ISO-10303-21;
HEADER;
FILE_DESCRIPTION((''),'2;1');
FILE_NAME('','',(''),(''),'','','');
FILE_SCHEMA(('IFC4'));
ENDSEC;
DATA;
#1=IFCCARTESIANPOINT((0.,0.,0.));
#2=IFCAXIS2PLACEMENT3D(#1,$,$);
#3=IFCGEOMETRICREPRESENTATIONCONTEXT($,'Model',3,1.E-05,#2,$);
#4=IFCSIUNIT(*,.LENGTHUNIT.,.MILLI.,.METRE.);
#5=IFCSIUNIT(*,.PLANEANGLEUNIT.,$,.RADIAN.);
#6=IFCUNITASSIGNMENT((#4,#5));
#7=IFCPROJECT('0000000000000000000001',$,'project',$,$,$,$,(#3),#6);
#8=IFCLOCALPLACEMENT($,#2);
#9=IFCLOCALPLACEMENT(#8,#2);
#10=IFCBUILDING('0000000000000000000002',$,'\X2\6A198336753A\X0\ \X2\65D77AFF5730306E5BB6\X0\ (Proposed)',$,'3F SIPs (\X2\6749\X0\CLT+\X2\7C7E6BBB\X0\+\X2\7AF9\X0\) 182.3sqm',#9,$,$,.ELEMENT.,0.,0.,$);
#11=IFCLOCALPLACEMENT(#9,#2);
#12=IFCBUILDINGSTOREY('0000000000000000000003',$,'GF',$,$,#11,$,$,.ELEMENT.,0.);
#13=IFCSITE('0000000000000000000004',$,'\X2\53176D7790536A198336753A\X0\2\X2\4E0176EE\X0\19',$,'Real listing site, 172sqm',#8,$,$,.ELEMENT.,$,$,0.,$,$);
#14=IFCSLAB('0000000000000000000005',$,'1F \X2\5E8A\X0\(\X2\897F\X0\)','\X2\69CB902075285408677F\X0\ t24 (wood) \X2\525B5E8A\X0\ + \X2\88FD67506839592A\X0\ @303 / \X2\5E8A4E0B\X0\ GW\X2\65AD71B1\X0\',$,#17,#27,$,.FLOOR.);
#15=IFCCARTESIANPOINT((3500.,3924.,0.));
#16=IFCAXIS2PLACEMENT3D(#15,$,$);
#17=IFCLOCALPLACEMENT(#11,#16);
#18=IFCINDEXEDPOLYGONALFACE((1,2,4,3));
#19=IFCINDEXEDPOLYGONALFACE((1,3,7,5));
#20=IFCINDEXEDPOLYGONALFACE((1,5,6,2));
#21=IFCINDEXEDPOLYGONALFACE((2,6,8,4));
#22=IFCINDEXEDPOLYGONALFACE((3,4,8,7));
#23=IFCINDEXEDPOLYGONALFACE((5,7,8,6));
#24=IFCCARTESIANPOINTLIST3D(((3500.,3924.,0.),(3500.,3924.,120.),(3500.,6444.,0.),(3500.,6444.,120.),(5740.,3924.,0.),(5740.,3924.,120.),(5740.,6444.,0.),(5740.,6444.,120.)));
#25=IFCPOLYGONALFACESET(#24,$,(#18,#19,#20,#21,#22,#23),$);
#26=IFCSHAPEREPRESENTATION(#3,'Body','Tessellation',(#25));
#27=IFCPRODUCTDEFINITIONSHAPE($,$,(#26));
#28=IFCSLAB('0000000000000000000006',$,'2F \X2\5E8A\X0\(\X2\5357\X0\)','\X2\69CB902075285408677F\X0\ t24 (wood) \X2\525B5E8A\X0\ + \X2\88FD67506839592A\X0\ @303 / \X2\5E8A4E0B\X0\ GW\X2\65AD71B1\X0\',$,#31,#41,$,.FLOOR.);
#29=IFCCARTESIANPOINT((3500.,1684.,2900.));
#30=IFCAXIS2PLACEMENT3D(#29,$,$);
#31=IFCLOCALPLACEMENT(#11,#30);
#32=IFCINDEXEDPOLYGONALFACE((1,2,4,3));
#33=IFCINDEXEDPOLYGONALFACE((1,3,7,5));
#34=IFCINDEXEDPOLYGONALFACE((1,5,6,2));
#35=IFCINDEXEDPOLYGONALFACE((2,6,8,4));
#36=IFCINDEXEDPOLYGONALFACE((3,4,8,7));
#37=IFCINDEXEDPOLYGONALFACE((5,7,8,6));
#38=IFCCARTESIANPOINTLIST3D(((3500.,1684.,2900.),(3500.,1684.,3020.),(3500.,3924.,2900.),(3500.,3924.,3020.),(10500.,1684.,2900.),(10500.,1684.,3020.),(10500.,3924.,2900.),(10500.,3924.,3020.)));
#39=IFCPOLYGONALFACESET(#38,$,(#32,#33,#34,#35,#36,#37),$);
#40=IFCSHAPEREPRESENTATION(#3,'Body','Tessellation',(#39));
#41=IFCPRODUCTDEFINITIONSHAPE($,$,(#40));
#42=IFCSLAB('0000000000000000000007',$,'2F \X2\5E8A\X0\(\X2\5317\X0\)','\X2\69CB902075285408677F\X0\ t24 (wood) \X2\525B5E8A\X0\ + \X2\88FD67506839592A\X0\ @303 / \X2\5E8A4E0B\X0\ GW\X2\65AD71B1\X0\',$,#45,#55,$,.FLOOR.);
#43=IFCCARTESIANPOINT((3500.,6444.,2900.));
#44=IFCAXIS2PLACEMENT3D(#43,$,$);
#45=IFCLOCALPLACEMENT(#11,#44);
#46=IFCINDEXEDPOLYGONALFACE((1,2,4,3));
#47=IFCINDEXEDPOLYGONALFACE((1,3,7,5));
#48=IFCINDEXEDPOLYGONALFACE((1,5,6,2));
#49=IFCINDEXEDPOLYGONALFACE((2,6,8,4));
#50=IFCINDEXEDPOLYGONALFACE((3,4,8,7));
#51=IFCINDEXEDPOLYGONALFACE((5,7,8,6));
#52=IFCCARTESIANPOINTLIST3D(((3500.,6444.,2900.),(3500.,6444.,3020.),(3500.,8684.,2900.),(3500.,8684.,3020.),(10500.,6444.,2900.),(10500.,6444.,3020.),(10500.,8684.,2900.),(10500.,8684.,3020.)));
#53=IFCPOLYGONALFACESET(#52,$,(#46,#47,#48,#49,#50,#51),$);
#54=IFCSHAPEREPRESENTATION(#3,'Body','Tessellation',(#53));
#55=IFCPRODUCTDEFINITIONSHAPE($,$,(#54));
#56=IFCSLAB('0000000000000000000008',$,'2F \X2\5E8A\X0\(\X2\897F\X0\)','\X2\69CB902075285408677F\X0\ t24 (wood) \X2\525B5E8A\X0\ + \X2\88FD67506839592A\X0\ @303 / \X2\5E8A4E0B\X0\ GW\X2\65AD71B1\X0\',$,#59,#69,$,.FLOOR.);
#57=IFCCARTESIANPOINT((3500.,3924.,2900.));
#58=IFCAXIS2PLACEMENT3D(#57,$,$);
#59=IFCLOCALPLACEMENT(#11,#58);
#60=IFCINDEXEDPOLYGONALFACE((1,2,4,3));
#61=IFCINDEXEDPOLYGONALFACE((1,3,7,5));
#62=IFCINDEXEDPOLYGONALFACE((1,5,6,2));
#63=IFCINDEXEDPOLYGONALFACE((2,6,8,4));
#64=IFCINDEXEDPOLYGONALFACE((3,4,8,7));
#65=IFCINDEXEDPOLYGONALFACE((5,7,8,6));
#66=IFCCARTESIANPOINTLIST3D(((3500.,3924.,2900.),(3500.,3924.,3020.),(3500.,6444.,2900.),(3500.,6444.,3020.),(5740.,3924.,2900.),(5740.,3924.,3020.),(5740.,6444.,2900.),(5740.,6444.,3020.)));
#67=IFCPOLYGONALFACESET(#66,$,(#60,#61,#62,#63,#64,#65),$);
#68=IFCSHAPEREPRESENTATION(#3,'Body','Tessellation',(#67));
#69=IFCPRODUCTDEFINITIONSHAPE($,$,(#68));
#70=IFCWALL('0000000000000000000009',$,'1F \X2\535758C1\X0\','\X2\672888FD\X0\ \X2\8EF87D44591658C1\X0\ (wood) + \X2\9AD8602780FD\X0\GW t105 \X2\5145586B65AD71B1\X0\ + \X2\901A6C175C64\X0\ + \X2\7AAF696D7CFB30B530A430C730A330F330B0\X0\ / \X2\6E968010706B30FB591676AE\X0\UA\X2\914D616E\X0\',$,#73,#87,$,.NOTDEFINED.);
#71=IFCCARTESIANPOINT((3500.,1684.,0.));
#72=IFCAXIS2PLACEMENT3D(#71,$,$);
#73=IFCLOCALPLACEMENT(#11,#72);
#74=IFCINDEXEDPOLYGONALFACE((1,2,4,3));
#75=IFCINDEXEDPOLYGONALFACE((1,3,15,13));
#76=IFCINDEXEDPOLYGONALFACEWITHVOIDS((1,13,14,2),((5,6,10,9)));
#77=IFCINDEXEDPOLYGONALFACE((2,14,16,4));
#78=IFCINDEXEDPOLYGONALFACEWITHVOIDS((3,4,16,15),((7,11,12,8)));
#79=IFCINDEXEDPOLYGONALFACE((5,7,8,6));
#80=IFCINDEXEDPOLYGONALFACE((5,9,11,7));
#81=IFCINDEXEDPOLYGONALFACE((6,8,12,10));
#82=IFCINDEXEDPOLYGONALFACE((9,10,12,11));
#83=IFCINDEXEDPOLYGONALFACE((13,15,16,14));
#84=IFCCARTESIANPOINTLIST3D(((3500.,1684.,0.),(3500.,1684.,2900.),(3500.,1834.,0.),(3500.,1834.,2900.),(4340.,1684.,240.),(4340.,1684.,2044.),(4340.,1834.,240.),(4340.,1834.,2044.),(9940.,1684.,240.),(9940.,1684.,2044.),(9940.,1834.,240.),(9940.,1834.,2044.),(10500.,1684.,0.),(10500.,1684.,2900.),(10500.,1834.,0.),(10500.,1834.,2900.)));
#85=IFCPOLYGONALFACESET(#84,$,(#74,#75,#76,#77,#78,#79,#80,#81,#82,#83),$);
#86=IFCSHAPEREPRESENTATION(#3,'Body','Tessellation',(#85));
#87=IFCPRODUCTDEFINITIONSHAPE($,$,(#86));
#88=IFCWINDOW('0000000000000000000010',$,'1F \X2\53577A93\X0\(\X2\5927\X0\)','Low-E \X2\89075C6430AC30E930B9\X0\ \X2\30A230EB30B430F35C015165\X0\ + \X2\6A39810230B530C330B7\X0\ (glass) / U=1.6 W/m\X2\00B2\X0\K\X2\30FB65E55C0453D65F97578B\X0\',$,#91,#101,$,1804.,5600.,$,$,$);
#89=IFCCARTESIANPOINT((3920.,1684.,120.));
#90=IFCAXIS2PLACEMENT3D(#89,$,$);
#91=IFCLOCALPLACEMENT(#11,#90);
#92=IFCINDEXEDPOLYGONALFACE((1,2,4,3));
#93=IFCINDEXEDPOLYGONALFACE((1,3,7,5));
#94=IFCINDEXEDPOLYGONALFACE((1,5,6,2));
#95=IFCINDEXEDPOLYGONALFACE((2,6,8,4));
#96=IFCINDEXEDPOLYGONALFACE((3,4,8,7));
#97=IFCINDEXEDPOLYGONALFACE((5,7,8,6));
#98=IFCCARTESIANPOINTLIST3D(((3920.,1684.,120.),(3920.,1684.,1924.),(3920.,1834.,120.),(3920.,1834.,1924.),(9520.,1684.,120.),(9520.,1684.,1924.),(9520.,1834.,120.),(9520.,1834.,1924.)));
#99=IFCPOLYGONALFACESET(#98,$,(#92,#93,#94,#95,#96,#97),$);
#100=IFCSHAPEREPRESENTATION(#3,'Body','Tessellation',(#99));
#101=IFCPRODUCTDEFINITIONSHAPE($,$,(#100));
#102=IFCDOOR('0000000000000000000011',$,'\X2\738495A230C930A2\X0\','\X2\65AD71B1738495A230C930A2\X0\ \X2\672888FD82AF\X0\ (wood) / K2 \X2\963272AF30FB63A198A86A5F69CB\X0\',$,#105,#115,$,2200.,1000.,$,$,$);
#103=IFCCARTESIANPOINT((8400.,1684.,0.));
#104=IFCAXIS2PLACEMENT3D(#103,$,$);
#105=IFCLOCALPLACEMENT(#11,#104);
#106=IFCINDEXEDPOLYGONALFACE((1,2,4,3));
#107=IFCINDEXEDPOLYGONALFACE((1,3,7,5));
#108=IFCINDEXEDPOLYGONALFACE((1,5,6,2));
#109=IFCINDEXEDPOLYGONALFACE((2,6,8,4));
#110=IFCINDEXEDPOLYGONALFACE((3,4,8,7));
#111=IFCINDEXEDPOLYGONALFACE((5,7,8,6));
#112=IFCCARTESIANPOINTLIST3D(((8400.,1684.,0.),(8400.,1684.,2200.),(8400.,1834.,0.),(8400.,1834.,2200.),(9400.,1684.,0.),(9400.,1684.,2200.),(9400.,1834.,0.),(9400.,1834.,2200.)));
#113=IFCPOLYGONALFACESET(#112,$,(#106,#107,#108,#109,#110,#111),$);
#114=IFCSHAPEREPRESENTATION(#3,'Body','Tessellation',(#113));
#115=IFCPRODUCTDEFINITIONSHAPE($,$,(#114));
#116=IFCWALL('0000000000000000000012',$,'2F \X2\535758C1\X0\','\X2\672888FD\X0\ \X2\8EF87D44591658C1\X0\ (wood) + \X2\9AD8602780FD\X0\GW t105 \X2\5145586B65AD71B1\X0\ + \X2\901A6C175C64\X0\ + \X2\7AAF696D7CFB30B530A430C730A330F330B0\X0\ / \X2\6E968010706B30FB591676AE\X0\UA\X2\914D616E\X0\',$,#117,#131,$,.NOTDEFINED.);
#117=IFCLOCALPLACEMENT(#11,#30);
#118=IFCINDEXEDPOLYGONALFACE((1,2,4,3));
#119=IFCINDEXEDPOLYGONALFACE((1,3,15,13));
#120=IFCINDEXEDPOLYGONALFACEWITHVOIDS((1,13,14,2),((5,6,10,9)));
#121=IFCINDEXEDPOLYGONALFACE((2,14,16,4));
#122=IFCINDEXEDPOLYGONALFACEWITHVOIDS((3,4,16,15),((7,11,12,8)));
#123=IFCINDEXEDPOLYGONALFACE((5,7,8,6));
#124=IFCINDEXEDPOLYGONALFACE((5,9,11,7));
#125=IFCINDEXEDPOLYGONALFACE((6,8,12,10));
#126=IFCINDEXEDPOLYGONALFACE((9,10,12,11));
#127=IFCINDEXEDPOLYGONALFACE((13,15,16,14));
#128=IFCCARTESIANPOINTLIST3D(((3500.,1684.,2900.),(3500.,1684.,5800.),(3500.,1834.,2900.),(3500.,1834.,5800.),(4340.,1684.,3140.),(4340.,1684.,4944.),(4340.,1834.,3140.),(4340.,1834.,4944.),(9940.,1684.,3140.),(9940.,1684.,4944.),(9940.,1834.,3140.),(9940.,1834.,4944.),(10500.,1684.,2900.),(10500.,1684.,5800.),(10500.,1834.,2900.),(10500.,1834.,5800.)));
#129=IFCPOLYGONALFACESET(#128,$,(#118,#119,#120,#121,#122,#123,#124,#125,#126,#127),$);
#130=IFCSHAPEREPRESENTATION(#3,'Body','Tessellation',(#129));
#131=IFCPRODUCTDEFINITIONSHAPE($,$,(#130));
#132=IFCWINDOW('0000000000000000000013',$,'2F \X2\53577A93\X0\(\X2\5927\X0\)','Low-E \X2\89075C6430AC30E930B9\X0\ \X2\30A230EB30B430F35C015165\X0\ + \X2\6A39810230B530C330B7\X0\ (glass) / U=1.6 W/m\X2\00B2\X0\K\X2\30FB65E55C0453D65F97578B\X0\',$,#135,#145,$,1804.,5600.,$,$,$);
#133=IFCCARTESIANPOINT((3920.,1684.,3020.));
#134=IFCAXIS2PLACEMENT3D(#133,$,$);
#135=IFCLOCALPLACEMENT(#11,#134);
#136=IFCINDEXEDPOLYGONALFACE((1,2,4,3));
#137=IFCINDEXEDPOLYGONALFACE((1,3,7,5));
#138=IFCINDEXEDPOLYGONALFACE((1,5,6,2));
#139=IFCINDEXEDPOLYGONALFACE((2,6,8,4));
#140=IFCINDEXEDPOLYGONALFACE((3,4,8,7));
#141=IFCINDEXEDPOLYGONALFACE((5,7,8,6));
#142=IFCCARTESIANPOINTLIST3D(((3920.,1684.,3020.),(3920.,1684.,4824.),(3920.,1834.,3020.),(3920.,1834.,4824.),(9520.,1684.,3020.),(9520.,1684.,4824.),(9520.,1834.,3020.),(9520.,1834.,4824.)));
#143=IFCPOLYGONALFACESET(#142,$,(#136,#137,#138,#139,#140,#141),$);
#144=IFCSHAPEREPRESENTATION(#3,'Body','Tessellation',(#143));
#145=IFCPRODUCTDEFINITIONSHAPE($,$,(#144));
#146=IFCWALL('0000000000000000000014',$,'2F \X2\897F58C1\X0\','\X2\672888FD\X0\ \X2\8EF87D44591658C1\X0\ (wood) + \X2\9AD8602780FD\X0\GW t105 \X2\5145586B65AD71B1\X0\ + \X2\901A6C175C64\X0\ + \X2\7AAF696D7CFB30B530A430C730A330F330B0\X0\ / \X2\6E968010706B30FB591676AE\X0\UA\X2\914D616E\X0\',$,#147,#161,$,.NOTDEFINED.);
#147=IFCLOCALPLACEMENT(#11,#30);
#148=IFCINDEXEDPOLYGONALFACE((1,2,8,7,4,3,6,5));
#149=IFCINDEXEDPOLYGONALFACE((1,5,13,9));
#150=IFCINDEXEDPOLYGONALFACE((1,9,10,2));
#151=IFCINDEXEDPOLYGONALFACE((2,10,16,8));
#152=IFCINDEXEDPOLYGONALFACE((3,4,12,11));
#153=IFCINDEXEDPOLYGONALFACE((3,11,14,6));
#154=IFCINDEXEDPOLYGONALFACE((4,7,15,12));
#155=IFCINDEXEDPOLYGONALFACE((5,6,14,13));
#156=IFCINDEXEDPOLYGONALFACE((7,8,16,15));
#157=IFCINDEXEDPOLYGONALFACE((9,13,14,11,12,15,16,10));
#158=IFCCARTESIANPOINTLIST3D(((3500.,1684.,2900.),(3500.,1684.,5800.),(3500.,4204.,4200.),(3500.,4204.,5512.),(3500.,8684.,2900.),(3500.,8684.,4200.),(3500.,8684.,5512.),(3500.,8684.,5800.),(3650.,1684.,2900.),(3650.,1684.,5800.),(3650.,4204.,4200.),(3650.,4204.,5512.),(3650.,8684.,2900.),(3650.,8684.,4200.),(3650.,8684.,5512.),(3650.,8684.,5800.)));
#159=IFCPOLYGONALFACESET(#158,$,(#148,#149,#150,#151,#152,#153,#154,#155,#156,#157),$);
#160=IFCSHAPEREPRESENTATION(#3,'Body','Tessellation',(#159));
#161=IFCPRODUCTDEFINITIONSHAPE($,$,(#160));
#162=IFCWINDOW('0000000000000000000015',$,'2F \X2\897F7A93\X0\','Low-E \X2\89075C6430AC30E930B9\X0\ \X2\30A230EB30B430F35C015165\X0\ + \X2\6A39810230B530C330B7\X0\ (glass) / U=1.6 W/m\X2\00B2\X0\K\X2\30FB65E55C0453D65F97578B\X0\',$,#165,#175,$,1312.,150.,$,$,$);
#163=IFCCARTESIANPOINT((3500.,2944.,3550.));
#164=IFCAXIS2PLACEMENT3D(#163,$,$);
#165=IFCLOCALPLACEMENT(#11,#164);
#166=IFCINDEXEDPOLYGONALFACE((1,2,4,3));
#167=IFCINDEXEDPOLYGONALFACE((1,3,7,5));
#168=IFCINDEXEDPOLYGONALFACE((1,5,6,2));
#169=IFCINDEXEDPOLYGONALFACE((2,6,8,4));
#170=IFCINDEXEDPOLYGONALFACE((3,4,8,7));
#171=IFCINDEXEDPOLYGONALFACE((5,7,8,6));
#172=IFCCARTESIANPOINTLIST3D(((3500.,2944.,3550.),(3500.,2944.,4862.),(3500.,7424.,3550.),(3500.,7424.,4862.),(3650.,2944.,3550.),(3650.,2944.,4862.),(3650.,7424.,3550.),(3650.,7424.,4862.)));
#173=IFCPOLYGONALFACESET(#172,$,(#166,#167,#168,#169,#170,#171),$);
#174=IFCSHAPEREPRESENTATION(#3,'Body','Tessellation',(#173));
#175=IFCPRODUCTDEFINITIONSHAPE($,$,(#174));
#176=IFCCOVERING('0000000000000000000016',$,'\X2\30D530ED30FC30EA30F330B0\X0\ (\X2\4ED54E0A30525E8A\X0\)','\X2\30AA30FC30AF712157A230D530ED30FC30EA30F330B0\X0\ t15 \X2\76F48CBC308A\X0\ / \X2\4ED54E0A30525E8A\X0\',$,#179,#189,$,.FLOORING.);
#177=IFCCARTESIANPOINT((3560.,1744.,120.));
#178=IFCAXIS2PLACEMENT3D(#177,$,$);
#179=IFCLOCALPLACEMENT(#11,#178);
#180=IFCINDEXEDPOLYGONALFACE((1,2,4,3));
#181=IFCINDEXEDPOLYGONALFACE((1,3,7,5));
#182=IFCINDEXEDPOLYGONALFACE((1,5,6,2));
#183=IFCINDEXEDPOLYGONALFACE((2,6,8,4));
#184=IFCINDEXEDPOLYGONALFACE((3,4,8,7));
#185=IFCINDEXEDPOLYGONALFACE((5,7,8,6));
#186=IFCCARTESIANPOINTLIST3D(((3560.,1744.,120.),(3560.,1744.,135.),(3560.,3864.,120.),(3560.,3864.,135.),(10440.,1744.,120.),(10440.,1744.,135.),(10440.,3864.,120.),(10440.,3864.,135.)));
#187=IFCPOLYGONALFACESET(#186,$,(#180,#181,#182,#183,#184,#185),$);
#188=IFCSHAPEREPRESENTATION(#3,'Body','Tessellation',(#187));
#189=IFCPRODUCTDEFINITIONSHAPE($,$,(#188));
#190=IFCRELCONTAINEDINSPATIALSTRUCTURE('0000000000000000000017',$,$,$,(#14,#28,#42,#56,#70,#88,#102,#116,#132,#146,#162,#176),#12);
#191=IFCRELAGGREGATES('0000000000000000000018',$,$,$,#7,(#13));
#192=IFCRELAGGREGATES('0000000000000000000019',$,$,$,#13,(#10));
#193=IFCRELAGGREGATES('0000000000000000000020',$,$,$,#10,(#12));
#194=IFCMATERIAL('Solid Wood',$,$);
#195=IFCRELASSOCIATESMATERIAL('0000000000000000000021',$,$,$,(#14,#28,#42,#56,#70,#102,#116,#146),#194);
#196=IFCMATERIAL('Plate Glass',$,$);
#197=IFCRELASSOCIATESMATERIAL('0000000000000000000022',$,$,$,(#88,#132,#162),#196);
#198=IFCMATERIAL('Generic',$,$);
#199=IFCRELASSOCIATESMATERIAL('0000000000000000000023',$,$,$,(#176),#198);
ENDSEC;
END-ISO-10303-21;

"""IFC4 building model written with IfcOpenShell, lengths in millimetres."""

from ifc_helpers import new_model, si_unit, frame, frame_2d, origin, place, context, project, spatial, rectangle, extrude, material, element, fill, save


model = new_model("IFC4")

# Units and contexts
model_context = context("Model", 3, precision=1e-05, world=origin())
ifc_project = project(units=[si_unit("LENGTHUNIT", "METRE", prefix="MILLI"), si_unit("PLANEANGLEUNIT", "RADIAN")], contexts=[model_context])

# Site, building, storey
site_placement = place(None, origin())
site = spatial("IfcSite", under=ifc_project, at=site_placement, Name="北海道標茶町2丁目19", ObjectType="Real listing site, 172sqm", CompositionType="ELEMENT", RefElevation=0.0)
building_placement = place(site_placement, origin())
building = spatial("IfcBuilding", under=site, at=building_placement, Name="標茶町 旗竿地の家 (Proposed)", ObjectType="3F SIPs (杉CLT+籾殻+竹) 182.3sqm", CompositionType="ELEMENT", ElevationOfRefHeight=0.0, ElevationOfTerrain=0.0)
storey_placement = place(building_placement, origin())
storey = spatial("IfcBuildingStorey", under=building, at=storey_placement, Name="GF", CompositionType="ELEMENT", Elevation=0.0)

# Slabs
ifc_material_1 = material(Name="Solid Wood")
slab_1_placement = place(storey_placement, frame((3500.0, 3924.0, 0.0)))
element("IfcSlab", 1, at=slab_1_placement, inside=storey, material=ifc_material_1, Name="1F 床(西)", Description="構造用合板 t24 (wood) 剛床 + 製材根太 @303 / 床下 GW断熱", PredefinedType="FLOOR", context=model_context, shape_type="SweptSolid", body=[
    extrude(rectangle(XDim=2240.0, YDim=2520.0, at=frame_2d((1120.0, 1260.0))), frame((3500.0, 3924.0, 0.0)), (0.0, 0.0, 1.0), 120.0),
])
slab_2_placement = place(storey_placement, frame((3500.0, 1684.0, 2900.0)))
element("IfcSlab", 2, at=slab_2_placement, inside=storey, material=ifc_material_1, Name="2F 床(南)", Description="構造用合板 t24 (wood) 剛床 + 製材根太 @303 / 床下 GW断熱", PredefinedType="FLOOR", context=model_context, shape_type="SweptSolid", body=[
    extrude(rectangle(XDim=7000.0, YDim=2240.0, at=frame_2d((3500.0, 1120.0))), frame((3500.0, 1684.0, 2900.0)), (0.0, 0.0, 1.0), 120.0),
])
slab_3_placement = place(storey_placement, frame((3500.0, 6444.0, 2900.0)))
element("IfcSlab", 3, at=slab_3_placement, inside=storey, material=ifc_material_1, Name="2F 床(北)", Description="構造用合板 t24 (wood) 剛床 + 製材根太 @303 / 床下 GW断熱", PredefinedType="FLOOR", context=model_context, shape_type="SweptSolid", body=[
    extrude(rectangle(XDim=7000.0, YDim=2240.0, at=frame_2d((3500.0, 1120.0))), frame((3500.0, 6444.0, 2900.0)), (0.0, 0.0, 1.0), 120.0),
])
slab_4_placement = place(storey_placement, frame((3500.0, 3924.0, 2900.0)))
element("IfcSlab", 4, at=slab_4_placement, inside=storey, material=ifc_material_1, Name="2F 床(西)", Description="構造用合板 t24 (wood) 剛床 + 製材根太 @303 / 床下 GW断熱", PredefinedType="FLOOR", context=model_context, shape_type="SweptSolid", body=[
    extrude(rectangle(XDim=2240.0, YDim=2520.0, at=frame_2d((1120.0, 1260.0))), frame((3500.0, 3924.0, 2900.0)), (0.0, 0.0, 1.0), 120.0),
])

# Wall, openings, window, door
wall_1_placement = place(storey_placement, frame((3500.0, 1684.0, 0.0)))
wall_1 = element("IfcWall", 5, at=wall_1_placement, inside=storey, material=ifc_material_1, Name="1F 南壁", Description="木製 軸組外壁 (wood) + 高性能GW t105 充填断熱 + 通気層 + 窯業系サイディング / 準耐火・外皮UA配慮", PredefinedType="NOTDEFINED", context=model_context, shape_type="SweptSolid", body=[
    extrude(rectangle(XDim=7000.0, YDim=150.0, at=frame_2d((3500.0, 75.0))), frame((3500.0, 1684.0, 0.0)), (0.0, 0.0, 1.0), 2900.0),
])
opening_1_placement = place(storey_placement, frame((3920.0, 1684.0, 120.0)))
opening_1 = element("IfcOpeningElement", 6, at=opening_1_placement, cuts=wall_1, PredefinedType="NOTDEFINED", context=model_context, shape_type="SweptSolid", body=[
    extrude(rectangle(XDim=5600.0, YDim=150.0, at=frame_2d((2800.0, 75.0))), frame((3920.0, 1684.0, 120.0)), (0.0, 0.0, 1.0), 1804.0),
])
opening_2_placement = place(storey_placement, frame((8400.0, 1684.0, 0.0)))
opening_2 = element("IfcOpeningElement", 7, at=opening_2_placement, cuts=wall_1, PredefinedType="NOTDEFINED", context=model_context, shape_type="SweptSolid", body=[
    extrude(rectangle(XDim=1000.0, YDim=150.0, at=frame_2d((500.0, 75.0))), frame((8400.0, 1684.0, 0.0)), (0.0, 0.0, 1.0), 2200.0),
])
ifc_material_2 = material(Name="Plate Glass")
window_1_placement = place(storey_placement, frame((3920.0, 1684.0, 120.0)))
window_1 = element("IfcWindow", 8, at=window_1_placement, inside=storey, material=ifc_material_2, Name="1F 南窓(大)", Description="Low-E 複層ガラス アルゴン封入 + 樹脂サッシ (glass) / U=1.6 W/m²K・日射取得型", OverallHeight=1804.0, OverallWidth=5600.0, context=model_context, shape_type="SweptSolid", body=[
    extrude(rectangle(XDim=5600.0, YDim=150.0, at=frame_2d((2800.0, 75.0))), frame((3920.0, 1684.0, 120.0)), (0.0, 0.0, 1.0), 1804.0),
])
fill(opening_1, window_1)
door_placement = place(storey_placement, frame((8400.0, 1684.0, 0.0)))
door = element("IfcDoor", 9, at=door_placement, inside=storey, material=ifc_material_1, Name="玄関ドア", Description="断熱玄関ドア 木製芯 (wood) / K2 防犯・採風機構", OverallHeight=2200.0, OverallWidth=1000.0, context=model_context, shape_type="SweptSolid", body=[
    extrude(rectangle(XDim=1000.0, YDim=150.0, at=frame_2d((500.0, 75.0))), frame((8400.0, 1684.0, 0.0)), (0.0, 0.0, 1.0), 2200.0),
])
fill(opening_2, door)

# Wall, opening, window
wall_2_placement = place(storey_placement, frame((3500.0, 1684.0, 2900.0)))
wall_2 = element("IfcWall", 10, at=wall_2_placement, inside=storey, material=ifc_material_1, Name="2F 南壁", Description="木製 軸組外壁 (wood) + 高性能GW t105 充填断熱 + 通気層 + 窯業系サイディング / 準耐火・外皮UA配慮", PredefinedType="NOTDEFINED", context=model_context, shape_type="SweptSolid", body=[
    extrude(rectangle(XDim=7000.0, YDim=150.0, at=frame_2d((3500.0, 75.0))), frame((3500.0, 1684.0, 2900.0)), (0.0, 0.0, 1.0), 2900.0),
])
opening_3_placement = place(storey_placement, frame((3920.0, 1684.0, 3020.0)))
opening_3 = element("IfcOpeningElement", 11, at=opening_3_placement, cuts=wall_2, PredefinedType="NOTDEFINED", context=model_context, shape_type="SweptSolid", body=[
    extrude(rectangle(XDim=5600.0, YDim=150.0, at=frame_2d((2800.0, 75.0))), frame((3920.0, 1684.0, 3020.0)), (0.0, 0.0, 1.0), 1804.0),
])
window_2_placement = place(storey_placement, frame((3920.0, 1684.0, 3020.0)))
window_2 = element("IfcWindow", 12, at=window_2_placement, inside=storey, material=ifc_material_2, Name="2F 南窓(大)", Description="Low-E 複層ガラス アルゴン封入 + 樹脂サッシ (glass) / U=1.6 W/m²K・日射取得型", OverallHeight=1804.0, OverallWidth=5600.0, context=model_context, shape_type="SweptSolid", body=[
    extrude(rectangle(XDim=5600.0, YDim=150.0, at=frame_2d((2800.0, 75.0))), frame((3920.0, 1684.0, 3020.0)), (0.0, 0.0, 1.0), 1804.0),
])
fill(opening_3, window_2)

# Wall, opening, window
wall_3_placement = place(storey_placement, frame((3500.0, 1684.0, 2900.0)))
wall_3 = element("IfcWall", 13, at=wall_3_placement, inside=storey, material=ifc_material_1, Name="2F 西壁", Description="木製 軸組外壁 (wood) + 高性能GW t105 充填断熱 + 通気層 + 窯業系サイディング / 準耐火・外皮UA配慮", PredefinedType="NOTDEFINED", context=model_context, shape_type="SweptSolid", body=[
    extrude(rectangle(XDim=150.0, YDim=7000.0, at=frame_2d((75.0, 3500.0))), frame((3500.0, 1684.0, 2900.0)), (0.0, 0.0, 1.0), 2900.0),
])
opening_4_placement = place(storey_placement, frame((3500.0, 2944.0, 3550.0)))
opening_4 = element("IfcOpeningElement", 14, at=opening_4_placement, cuts=wall_3, PredefinedType="NOTDEFINED", context=model_context, shape_type="SweptSolid", body=[
    extrude(rectangle(XDim=150.0, YDim=4480.0, at=frame_2d((75.0, 2240.0))), frame((3500.0, 2944.0, 3550.0)), (0.0, 0.0, 1.0), 1312.0),
])
window_3_placement = place(storey_placement, frame((3500.0, 2944.0, 3550.0)))
window_3 = element("IfcWindow", 15, at=window_3_placement, inside=storey, material=ifc_material_2, Name="2F 西窓", Description="Low-E 複層ガラス アルゴン封入 + 樹脂サッシ (glass) / U=1.6 W/m²K・日射取得型", OverallHeight=1312.0, OverallWidth=150.0, context=model_context, shape_type="SweptSolid", body=[
    extrude(rectangle(XDim=150.0, YDim=4480.0, at=frame_2d((75.0, 2240.0))), frame((3500.0, 2944.0, 3550.0)), (0.0, 0.0, 1.0), 1312.0),
])
fill(opening_4, window_3)

# Covering
ifc_material_3 = material(Name="Generic")
covering_1_placement = place(storey_placement, frame((3560.0, 1744.0, 120.0)))
element("IfcCovering", 16, at=covering_1_placement, inside=storey, material=ifc_material_3, Name="フローリング (仕上げ床)", Description="オーク無垢フローリング t15 直貼り / 仕上げ床", PredefinedType="FLOORING", context=model_context, shape_type="SweptSolid", body=[
    extrude(rectangle(XDim=6880.0, YDim=2120.0, at=frame_2d((3440.0, 1060.0))), frame((3560.0, 1744.0, 120.0)), (0.0, 0.0, 1.0), 15.0),
])

save(model, "model.ifc")
